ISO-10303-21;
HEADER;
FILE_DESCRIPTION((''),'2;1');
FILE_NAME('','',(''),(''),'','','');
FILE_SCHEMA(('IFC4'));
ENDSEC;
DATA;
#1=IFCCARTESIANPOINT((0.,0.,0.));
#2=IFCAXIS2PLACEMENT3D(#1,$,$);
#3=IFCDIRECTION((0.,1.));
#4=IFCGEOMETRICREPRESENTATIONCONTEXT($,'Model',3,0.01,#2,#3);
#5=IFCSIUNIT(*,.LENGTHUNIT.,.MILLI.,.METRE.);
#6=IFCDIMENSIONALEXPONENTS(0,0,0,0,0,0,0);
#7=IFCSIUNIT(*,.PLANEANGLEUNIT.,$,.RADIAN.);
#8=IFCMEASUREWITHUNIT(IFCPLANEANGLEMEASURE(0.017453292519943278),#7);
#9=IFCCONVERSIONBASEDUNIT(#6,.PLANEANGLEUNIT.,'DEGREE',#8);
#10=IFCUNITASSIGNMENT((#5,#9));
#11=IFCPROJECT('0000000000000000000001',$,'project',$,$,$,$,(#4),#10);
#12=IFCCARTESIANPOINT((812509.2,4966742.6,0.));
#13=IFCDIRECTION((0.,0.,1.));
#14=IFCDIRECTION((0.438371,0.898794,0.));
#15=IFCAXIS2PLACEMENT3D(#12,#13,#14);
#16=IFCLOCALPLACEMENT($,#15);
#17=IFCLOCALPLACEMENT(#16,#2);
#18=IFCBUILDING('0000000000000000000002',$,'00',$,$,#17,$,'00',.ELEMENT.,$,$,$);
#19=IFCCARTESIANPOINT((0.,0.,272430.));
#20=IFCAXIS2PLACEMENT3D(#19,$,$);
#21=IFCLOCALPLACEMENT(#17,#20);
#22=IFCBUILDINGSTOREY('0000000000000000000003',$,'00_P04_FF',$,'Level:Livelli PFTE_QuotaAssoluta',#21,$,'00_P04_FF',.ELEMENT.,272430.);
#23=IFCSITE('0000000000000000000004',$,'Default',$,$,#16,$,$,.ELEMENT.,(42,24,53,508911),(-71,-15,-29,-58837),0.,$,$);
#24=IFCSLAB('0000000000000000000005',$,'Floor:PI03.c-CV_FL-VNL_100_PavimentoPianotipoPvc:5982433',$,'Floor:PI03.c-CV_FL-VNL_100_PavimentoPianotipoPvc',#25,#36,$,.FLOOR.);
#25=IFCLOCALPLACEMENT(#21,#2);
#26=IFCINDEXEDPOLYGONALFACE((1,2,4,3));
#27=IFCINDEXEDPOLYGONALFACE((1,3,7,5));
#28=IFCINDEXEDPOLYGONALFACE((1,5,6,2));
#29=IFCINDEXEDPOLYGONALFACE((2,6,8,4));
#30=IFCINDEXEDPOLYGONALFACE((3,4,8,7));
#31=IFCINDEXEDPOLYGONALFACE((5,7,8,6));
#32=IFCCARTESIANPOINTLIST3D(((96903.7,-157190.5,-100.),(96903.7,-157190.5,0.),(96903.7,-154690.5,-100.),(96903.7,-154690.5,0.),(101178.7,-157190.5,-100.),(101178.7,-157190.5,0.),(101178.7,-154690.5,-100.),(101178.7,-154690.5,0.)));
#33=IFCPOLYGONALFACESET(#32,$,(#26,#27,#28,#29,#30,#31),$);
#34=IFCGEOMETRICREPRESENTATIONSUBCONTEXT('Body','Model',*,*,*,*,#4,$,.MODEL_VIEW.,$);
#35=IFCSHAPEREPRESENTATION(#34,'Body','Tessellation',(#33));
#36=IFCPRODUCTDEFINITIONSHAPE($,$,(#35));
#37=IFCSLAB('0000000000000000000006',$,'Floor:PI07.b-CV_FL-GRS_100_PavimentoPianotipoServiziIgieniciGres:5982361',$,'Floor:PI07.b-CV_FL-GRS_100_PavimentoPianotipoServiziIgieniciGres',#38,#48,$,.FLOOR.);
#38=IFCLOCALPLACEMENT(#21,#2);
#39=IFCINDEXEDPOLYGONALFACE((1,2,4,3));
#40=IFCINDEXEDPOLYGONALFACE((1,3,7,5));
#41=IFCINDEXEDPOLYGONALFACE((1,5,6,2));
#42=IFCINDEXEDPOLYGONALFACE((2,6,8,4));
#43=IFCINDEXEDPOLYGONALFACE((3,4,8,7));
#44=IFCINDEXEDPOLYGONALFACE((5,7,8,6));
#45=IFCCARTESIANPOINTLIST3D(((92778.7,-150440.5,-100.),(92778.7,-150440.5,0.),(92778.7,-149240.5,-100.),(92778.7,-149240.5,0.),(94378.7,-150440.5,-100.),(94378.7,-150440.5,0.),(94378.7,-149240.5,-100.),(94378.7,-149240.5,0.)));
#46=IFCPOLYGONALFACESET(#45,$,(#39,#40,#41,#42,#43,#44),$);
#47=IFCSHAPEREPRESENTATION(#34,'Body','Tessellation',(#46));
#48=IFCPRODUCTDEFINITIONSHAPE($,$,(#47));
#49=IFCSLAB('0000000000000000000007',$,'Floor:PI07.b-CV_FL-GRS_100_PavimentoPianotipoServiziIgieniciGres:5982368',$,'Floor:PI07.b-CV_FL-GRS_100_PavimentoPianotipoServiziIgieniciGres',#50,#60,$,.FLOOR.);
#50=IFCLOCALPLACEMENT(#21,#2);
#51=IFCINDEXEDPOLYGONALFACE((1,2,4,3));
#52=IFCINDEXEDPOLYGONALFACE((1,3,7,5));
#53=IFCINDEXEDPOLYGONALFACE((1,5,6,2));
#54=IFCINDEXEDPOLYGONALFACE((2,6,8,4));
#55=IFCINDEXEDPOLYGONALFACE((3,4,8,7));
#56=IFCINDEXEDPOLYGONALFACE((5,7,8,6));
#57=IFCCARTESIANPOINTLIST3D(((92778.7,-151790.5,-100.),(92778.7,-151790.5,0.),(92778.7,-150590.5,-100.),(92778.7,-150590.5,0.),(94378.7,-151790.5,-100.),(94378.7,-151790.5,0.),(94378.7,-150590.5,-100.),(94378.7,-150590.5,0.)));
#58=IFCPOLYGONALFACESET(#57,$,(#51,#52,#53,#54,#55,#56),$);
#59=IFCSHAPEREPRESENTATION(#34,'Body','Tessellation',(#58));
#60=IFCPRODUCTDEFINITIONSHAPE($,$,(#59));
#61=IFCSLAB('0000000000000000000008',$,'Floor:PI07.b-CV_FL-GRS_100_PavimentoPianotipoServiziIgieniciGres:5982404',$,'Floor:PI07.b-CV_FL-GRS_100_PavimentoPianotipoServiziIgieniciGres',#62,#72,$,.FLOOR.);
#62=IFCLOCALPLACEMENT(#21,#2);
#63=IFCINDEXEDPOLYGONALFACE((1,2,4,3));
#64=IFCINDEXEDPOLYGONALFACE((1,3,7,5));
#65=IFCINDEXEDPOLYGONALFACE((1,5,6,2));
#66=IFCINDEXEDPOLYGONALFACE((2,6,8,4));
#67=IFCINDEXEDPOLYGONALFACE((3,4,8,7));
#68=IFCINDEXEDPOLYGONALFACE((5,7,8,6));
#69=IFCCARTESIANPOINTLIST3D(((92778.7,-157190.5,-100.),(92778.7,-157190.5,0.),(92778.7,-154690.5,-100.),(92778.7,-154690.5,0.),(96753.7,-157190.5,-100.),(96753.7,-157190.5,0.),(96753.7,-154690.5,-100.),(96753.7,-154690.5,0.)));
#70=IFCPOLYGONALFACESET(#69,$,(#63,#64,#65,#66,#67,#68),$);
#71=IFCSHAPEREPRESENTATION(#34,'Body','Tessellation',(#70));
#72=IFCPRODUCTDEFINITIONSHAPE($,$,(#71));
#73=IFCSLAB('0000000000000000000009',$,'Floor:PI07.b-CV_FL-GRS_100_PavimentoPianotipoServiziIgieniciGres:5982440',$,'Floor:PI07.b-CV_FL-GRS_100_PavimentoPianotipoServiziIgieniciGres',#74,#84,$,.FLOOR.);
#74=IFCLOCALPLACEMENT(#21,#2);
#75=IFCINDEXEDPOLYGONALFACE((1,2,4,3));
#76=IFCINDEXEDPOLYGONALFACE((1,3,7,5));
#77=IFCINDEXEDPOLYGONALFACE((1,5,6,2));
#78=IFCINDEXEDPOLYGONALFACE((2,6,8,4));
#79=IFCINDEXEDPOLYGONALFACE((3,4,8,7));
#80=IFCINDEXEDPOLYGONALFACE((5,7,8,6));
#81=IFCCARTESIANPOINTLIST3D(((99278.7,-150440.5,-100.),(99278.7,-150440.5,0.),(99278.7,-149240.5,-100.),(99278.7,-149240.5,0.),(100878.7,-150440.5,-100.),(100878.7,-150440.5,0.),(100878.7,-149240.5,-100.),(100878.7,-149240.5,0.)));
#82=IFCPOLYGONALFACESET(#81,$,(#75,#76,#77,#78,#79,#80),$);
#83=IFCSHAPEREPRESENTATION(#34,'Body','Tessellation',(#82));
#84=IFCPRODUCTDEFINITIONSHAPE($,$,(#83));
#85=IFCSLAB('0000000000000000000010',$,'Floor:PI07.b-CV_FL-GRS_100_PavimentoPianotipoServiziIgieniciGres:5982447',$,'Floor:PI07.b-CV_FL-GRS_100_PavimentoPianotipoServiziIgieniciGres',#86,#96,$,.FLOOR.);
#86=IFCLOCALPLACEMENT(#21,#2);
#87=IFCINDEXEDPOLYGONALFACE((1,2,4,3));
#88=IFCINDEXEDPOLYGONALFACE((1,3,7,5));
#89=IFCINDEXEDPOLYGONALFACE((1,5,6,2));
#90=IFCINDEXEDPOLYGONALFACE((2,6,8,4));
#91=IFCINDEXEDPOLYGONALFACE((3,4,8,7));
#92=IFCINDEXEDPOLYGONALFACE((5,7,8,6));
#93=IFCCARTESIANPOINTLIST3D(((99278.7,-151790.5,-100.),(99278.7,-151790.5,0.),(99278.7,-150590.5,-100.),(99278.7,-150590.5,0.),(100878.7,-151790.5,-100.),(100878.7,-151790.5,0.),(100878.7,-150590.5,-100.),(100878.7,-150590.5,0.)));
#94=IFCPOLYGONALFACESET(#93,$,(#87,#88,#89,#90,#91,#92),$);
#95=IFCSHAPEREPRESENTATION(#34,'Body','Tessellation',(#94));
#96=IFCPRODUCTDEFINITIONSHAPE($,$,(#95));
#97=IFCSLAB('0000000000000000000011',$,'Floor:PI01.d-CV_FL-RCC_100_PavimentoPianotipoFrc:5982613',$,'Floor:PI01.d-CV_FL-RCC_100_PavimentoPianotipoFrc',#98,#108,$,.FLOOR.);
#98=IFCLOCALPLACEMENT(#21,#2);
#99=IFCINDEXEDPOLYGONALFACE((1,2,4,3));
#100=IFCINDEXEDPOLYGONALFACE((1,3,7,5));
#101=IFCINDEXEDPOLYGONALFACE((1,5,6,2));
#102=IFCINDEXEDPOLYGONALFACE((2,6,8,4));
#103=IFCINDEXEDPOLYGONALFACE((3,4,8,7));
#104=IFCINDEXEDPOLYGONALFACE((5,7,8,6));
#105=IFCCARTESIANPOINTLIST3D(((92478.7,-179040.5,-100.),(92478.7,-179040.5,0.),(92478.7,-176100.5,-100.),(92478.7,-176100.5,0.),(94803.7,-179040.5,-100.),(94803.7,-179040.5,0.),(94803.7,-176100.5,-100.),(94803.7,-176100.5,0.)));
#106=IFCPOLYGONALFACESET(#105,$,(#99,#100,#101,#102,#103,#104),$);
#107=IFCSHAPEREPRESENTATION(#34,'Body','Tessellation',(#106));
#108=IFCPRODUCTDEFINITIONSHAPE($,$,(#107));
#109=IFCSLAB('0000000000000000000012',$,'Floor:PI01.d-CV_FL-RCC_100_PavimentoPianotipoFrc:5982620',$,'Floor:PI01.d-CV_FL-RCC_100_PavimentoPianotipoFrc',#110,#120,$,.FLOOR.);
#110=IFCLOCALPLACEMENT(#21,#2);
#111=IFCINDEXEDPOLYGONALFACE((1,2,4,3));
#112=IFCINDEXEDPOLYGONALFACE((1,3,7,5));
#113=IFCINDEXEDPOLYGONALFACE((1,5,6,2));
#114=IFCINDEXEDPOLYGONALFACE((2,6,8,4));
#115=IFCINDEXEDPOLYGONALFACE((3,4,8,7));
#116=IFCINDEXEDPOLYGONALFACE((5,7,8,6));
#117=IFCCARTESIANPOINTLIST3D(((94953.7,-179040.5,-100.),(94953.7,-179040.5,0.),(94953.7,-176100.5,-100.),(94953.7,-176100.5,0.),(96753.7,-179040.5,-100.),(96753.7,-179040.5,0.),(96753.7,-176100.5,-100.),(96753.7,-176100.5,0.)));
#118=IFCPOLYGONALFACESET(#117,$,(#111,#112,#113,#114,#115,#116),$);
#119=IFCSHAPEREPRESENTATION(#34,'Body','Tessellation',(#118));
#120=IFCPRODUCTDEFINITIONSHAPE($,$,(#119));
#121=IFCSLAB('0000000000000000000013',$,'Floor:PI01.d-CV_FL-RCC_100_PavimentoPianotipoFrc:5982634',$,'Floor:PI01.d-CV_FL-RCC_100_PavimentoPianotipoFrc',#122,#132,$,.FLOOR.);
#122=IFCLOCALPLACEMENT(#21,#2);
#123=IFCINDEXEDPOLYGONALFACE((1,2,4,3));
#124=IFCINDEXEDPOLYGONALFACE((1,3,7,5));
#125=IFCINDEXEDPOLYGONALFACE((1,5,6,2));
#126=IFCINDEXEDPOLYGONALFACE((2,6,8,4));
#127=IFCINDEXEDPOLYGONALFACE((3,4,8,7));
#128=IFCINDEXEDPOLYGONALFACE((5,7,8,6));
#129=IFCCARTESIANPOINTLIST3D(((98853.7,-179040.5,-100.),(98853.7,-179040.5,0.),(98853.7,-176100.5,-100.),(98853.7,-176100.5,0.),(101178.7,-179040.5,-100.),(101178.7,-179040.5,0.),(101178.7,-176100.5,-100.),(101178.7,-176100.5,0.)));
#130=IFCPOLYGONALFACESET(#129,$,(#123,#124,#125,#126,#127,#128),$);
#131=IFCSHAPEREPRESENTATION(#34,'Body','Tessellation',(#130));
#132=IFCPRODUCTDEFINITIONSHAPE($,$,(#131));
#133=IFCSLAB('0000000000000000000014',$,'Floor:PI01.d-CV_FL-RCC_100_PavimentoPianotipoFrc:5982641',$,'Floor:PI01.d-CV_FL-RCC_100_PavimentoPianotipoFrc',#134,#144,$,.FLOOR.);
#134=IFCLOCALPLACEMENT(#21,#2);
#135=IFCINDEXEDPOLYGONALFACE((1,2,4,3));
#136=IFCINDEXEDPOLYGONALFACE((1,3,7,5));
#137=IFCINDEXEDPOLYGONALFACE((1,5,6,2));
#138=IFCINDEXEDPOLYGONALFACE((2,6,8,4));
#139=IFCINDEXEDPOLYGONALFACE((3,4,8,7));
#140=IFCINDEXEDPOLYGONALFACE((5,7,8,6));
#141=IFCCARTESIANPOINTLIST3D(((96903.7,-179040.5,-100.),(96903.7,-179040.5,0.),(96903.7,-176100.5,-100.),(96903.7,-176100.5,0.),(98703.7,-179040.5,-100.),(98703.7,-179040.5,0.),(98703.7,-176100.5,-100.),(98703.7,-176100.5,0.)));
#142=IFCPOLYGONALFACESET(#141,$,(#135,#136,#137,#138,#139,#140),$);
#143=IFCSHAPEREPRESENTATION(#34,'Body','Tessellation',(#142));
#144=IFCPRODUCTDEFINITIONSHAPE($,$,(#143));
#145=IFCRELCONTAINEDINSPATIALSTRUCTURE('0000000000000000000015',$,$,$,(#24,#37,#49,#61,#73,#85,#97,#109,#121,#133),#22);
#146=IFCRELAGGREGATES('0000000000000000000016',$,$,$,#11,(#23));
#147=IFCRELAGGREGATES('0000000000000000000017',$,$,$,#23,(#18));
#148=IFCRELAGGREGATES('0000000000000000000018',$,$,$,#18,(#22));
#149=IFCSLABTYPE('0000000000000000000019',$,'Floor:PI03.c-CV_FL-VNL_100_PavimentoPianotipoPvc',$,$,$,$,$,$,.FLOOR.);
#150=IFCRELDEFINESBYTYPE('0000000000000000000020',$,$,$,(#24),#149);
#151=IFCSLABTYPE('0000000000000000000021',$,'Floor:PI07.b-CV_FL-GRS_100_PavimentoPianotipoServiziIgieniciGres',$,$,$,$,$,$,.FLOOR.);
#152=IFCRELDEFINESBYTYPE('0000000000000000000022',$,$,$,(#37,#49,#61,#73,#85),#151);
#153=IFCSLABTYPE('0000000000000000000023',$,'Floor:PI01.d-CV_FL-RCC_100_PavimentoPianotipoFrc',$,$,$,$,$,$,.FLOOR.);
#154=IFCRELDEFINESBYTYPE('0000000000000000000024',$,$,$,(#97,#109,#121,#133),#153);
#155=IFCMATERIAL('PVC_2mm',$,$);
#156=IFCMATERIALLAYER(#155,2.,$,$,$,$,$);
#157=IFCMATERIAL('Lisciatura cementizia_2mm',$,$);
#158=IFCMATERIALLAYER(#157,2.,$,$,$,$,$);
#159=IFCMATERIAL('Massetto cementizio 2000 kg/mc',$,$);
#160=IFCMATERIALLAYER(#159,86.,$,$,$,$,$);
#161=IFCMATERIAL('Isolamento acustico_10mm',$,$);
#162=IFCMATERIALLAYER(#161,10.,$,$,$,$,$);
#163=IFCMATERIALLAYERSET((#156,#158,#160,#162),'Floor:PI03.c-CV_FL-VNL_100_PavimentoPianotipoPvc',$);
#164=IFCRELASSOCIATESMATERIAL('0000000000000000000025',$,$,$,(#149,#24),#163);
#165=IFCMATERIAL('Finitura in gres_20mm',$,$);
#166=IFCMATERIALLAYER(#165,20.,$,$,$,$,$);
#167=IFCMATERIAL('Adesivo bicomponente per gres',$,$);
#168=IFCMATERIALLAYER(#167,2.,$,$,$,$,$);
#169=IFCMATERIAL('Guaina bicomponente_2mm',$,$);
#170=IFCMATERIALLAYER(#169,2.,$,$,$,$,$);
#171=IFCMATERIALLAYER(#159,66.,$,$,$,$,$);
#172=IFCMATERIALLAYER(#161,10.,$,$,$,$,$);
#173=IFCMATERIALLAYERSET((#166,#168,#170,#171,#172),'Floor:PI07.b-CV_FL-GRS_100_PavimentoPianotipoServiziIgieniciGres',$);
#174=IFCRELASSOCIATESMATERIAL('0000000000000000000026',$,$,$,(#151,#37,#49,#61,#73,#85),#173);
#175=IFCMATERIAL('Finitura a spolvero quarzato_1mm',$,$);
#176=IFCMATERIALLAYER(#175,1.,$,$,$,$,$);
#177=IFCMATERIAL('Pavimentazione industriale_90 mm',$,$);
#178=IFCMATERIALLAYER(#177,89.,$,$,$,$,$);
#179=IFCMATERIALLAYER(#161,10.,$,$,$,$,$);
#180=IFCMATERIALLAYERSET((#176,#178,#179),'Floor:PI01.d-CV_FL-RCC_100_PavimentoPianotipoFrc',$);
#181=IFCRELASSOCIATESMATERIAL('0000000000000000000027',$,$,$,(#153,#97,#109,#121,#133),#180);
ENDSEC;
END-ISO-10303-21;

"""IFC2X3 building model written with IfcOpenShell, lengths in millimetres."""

from ifc_helpers import new_model, entity, si_unit, converted_unit, direction, frame, frame_2d, origin, place, context, subcontext, project, spatial, rectangle, extrude, material, layer, layer_set, layer_usage, type_object, element, save


model = new_model("IFC2X3")

# Units and contexts
model_context = context("Model", 3, precision=0.01, world=origin(), true_north=direction((0.0, 1.0)))
body_context = subcontext(model_context, "Body", "Model", "MODEL_VIEW")
ifc_project = project(units=[si_unit("LENGTHUNIT", "METRE", prefix="MILLI"), converted_unit("PLANEANGLEUNIT", "DEGREE", entity("IfcPlaneAngleMeasure", 0.017453292519943278), si_unit("PLANEANGLEUNIT", "RADIAN"), dimensions=[0, 0, 0, 0, 0, 0, 0])], contexts=[model_context])

# Site, building, storey
site_placement = place(None, frame((812509.2, 4966742.6, 0.0), z_axis=(0.0, 0.0, 1.0), x_axis=(0.438371, 0.898794, 0.0)))
site = spatial("IfcSite", under=ifc_project, at=site_placement, Name="Default", CompositionType="ELEMENT", RefLatitude=(42, 24, 53, 508911), RefLongitude=(-71, -15, -29, -58837), RefElevation=0.0)
building_placement = place(site_placement, origin())
building = spatial("IfcBuilding", under=site, at=building_placement, Name="00", LongName="00", CompositionType="ELEMENT")
storey_placement = place(building_placement, frame((0.0, 0.0, 272430.0)))
storey = spatial("IfcBuildingStorey", under=building, at=storey_placement, Name="00_P04_FF", ObjectType="Level:Livelli PFTE_QuotaAssoluta", LongName="00_P04_FF", CompositionType="ELEMENT", Elevation=272430.0)

# Slabs
ifc_material_1 = material(Name="PVC_2mm")
ifc_layer_1 = layer(ifc_material_1, 2.0)
ifc_material_2 = material(Name="Lisciatura cementizia_2mm")
ifc_layer_2 = layer(ifc_material_2, 2.0)
ifc_material_3 = material(Name="Massetto cementizio 2000 kg/mc")
ifc_layer_3 = layer(ifc_material_3, 86.0)
ifc_material_4 = material(Name="Isolamento acustico_10mm")
ifc_layer_4 = layer(ifc_material_4, 10.0)
ifc_layer_set_1 = layer_set([ifc_layer_1, ifc_layer_2, ifc_layer_3, ifc_layer_4], Name="Floor:PI03.c-CV_FL-VNL_100_PavimentoPianotipoPvc")
slab_type_1 = type_object("IfcSlabType", Name="Floor:PI03.c-CV_FL-VNL_100_PavimentoPianotipoPvc", PredefinedType="FLOOR", material=ifc_layer_set_1)
ifc_layer_usage_1 = layer_usage(ifc_layer_set_1, "AXIS3", "POSITIVE", 0.0)
slab_1_placement = place(storey_placement, origin())
element("IfcSlab", 1, at=slab_1_placement, inside=storey, type_object=slab_type_1, material=ifc_layer_usage_1, Name="Floor:PI03.c-CV_FL-VNL_100_PavimentoPianotipoPvc:5982433", ObjectType="Floor:PI03.c-CV_FL-VNL_100_PavimentoPianotipoPvc", PredefinedType="FLOOR", context=body_context, shape_type="SweptSolid", body=[
    extrude(rectangle(XDim=2500.0, YDim=4275.0, at=frame_2d((0.0, 0.0), x_axis=(1.0, 0.0))), frame((99041.2, -155940.5, 0.0), z_axis=(0.0, 0.0, -1.0), x_axis=(0.0, 1.0, 0.0)), (0.0, 0.0, 1.0), 100.0),
])
ifc_material_5 = material(Name="Finitura in gres_20mm")
ifc_layer_5 = layer(ifc_material_5, 20.0)
ifc_material_6 = material(Name="Adesivo bicomponente per gres")
ifc_layer_6 = layer(ifc_material_6, 2.0)
ifc_material_7 = material(Name="Guaina bicomponente_2mm")
ifc_layer_7 = layer(ifc_material_7, 2.0)
ifc_layer_8 = layer(ifc_material_3, 66.0)
ifc_layer_9 = layer(ifc_material_4, 10.0)
ifc_layer_set_2 = layer_set([ifc_layer_5, ifc_layer_6, ifc_layer_7, ifc_layer_8, ifc_layer_9], Name="Floor:PI07.b-CV_FL-GRS_100_PavimentoPianotipoServiziIgieniciGres")
slab_type_2 = type_object("IfcSlabType", Name="Floor:PI07.b-CV_FL-GRS_100_PavimentoPianotipoServiziIgieniciGres", PredefinedType="FLOOR", material=ifc_layer_set_2)
ifc_layer_usage_2 = layer_usage(ifc_layer_set_2, "AXIS3", "POSITIVE", 0.0)
slab_2_placement = place(storey_placement, origin())
element("IfcSlab", 2, at=slab_2_placement, inside=storey, type_object=slab_type_2, material=ifc_layer_usage_2, Name="Floor:PI07.b-CV_FL-GRS_100_PavimentoPianotipoServiziIgieniciGres:5982361", ObjectType="Floor:PI07.b-CV_FL-GRS_100_PavimentoPianotipoServiziIgieniciGres", PredefinedType="FLOOR", context=body_context, shape_type="SweptSolid", body=[
    extrude(rectangle(XDim=1200.0, YDim=1600.0, at=frame_2d((0.0, 0.0), x_axis=(1.0, 0.0))), frame((93578.7, -149840.5, 0.0), z_axis=(0.0, 0.0, -1.0), x_axis=(0.0, 1.0, 0.0)), (0.0, 0.0, 1.0), 100.0),
])
ifc_layer_usage_3 = layer_usage(ifc_layer_set_2, "AXIS3", "POSITIVE", 0.0)
slab_3_placement = place(storey_placement, origin())
element("IfcSlab", 3, at=slab_3_placement, inside=storey, type_object=slab_type_2, material=ifc_layer_usage_3, Name="Floor:PI07.b-CV_FL-GRS_100_PavimentoPianotipoServiziIgieniciGres:5982368", ObjectType="Floor:PI07.b-CV_FL-GRS_100_PavimentoPianotipoServiziIgieniciGres", PredefinedType="FLOOR", context=body_context, shape_type="SweptSolid", body=[
    extrude(rectangle(XDim=1200.0, YDim=1600.0, at=frame_2d((0.0, 0.0), x_axis=(1.0, 0.0))), frame((93578.7, -151190.5, 0.0), z_axis=(0.0, 0.0, -1.0), x_axis=(0.0, 1.0, 0.0)), (0.0, 0.0, 1.0), 100.0),
])
ifc_layer_usage_4 = layer_usage(ifc_layer_set_2, "AXIS3", "POSITIVE", 0.0)
slab_4_placement = place(storey_placement, origin())
element("IfcSlab", 4, at=slab_4_placement, inside=storey, type_object=slab_type_2, material=ifc_layer_usage_4, Name="Floor:PI07.b-CV_FL-GRS_100_PavimentoPianotipoServiziIgieniciGres:5982404", ObjectType="Floor:PI07.b-CV_FL-GRS_100_PavimentoPianotipoServiziIgieniciGres", PredefinedType="FLOOR", context=body_context, shape_type="SweptSolid", body=[
    extrude(rectangle(XDim=2500.0, YDim=3975.0, at=frame_2d((0.0, 0.0), x_axis=(1.0, 0.0))), frame((94766.2, -155940.5, 0.0), z_axis=(0.0, 0.0, -1.0), x_axis=(0.0, 1.0, 0.0)), (0.0, 0.0, 1.0), 100.0),
])
ifc_layer_usage_5 = layer_usage(ifc_layer_set_2, "AXIS3", "POSITIVE", 0.0)
slab_5_placement = place(storey_placement, origin())
element("IfcSlab", 5, at=slab_5_placement, inside=storey, type_object=slab_type_2, material=ifc_layer_usage_5, Name="Floor:PI07.b-CV_FL-GRS_100_PavimentoPianotipoServiziIgieniciGres:5982440", ObjectType="Floor:PI07.b-CV_FL-GRS_100_PavimentoPianotipoServiziIgieniciGres", PredefinedType="FLOOR", context=body_context, shape_type="SweptSolid", body=[
    extrude(rectangle(XDim=1200.0, YDim=1600.0, at=frame_2d((0.0, 0.0), x_axis=(1.0, 0.0))), frame((100078.7, -149840.5, 0.0), z_axis=(0.0, 0.0, -1.0), x_axis=(0.0, 1.0, 0.0)), (0.0, 0.0, 1.0), 100.0),
])
ifc_layer_usage_6 = layer_usage(ifc_layer_set_2, "AXIS3", "POSITIVE", 0.0)
slab_6_placement = place(storey_placement, origin())
element("IfcSlab", 6, at=slab_6_placement, inside=storey, type_object=slab_type_2, material=ifc_layer_usage_6, Name="Floor:PI07.b-CV_FL-GRS_100_PavimentoPianotipoServiziIgieniciGres:5982447", ObjectType="Floor:PI07.b-CV_FL-GRS_100_PavimentoPianotipoServiziIgieniciGres", PredefinedType="FLOOR", context=body_context, shape_type="SweptSolid", body=[
    extrude(rectangle(XDim=1200.0, YDim=1600.0, at=frame_2d((0.0, 0.0), x_axis=(1.0, 0.0))), frame((100078.7, -151190.5, 0.0), z_axis=(0.0, 0.0, -1.0), x_axis=(0.0, 1.0, 0.0)), (0.0, 0.0, 1.0), 100.0),
])
ifc_material_8 = material(Name="Finitura a spolvero quarzato_1mm")
ifc_layer_10 = layer(ifc_material_8, 1.0)
ifc_material_9 = material(Name="Pavimentazione industriale_90 mm")
ifc_layer_11 = layer(ifc_material_9, 89.0)
ifc_layer_12 = layer(ifc_material_4, 10.0)
ifc_layer_set_3 = layer_set([ifc_layer_10, ifc_layer_11, ifc_layer_12], Name="Floor:PI01.d-CV_FL-RCC_100_PavimentoPianotipoFrc")
slab_type_3 = type_object("IfcSlabType", Name="Floor:PI01.d-CV_FL-RCC_100_PavimentoPianotipoFrc", PredefinedType="FLOOR", material=ifc_layer_set_3)
ifc_layer_usage_7 = layer_usage(ifc_layer_set_3, "AXIS3", "POSITIVE", 0.0)
slab_7_placement = place(storey_placement, origin())
element("IfcSlab", 7, at=slab_7_placement, inside=storey, type_object=slab_type_3, material=ifc_layer_usage_7, Name="Floor:PI01.d-CV_FL-RCC_100_PavimentoPianotipoFrc:5982613", ObjectType="Floor:PI01.d-CV_FL-RCC_100_PavimentoPianotipoFrc", PredefinedType="FLOOR", context=body_context, shape_type="SweptSolid", body=[
    extrude(rectangle(XDim=2940.0, YDim=2325.0, at=frame_2d((0.0, 0.0), x_axis=(1.0, 0.0))), frame((93641.2, -177570.5, 0.0), z_axis=(0.0, 0.0, -1.0), x_axis=(0.0, 1.0, 0.0)), (0.0, 0.0, 1.0), 100.0),
])
ifc_layer_usage_8 = layer_usage(ifc_layer_set_3, "AXIS3", "POSITIVE", 0.0)
slab_8_placement = place(storey_placement, origin())
element("IfcSlab", 8, at=slab_8_placement, inside=storey, type_object=slab_type_3, material=ifc_layer_usage_8, Name="Floor:PI01.d-CV_FL-RCC_100_PavimentoPianotipoFrc:5982620", ObjectType="Floor:PI01.d-CV_FL-RCC_100_PavimentoPianotipoFrc", PredefinedType="FLOOR", context=body_context, shape_type="SweptSolid", body=[
    extrude(rectangle(XDim=2940.0, YDim=1800.0, at=frame_2d((0.0, 0.0), x_axis=(1.0, 0.0))), frame((95853.7, -177570.5, 0.0), z_axis=(0.0, 0.0, -1.0), x_axis=(0.0, 1.0, 0.0)), (0.0, 0.0, 1.0), 100.0),
])
ifc_layer_usage_9 = layer_usage(ifc_layer_set_3, "AXIS3", "POSITIVE", 0.0)
slab_9_placement = place(storey_placement, origin())
element("IfcSlab", 9, at=slab_9_placement, inside=storey, type_object=slab_type_3, material=ifc_layer_usage_9, Name="Floor:PI01.d-CV_FL-RCC_100_PavimentoPianotipoFrc:5982634", ObjectType="Floor:PI01.d-CV_FL-RCC_100_PavimentoPianotipoFrc", PredefinedType="FLOOR", context=body_context, shape_type="SweptSolid", body=[
    extrude(rectangle(XDim=2940.0, YDim=2325.0, at=frame_2d((0.0, 0.0), x_axis=(1.0, 0.0))), frame((100016.2, -177570.5, 0.0), z_axis=(0.0, 0.0, -1.0), x_axis=(0.0, 1.0, 0.0)), (0.0, 0.0, 1.0), 100.0),
])
ifc_layer_usage_10 = layer_usage(ifc_layer_set_3, "AXIS3", "POSITIVE", 0.0)
slab_10_placement = place(storey_placement, origin())
element("IfcSlab", 10, at=slab_10_placement, inside=storey, type_object=slab_type_3, material=ifc_layer_usage_10, Name="Floor:PI01.d-CV_FL-RCC_100_PavimentoPianotipoFrc:5982641", ObjectType="Floor:PI01.d-CV_FL-RCC_100_PavimentoPianotipoFrc", PredefinedType="FLOOR", context=body_context, shape_type="SweptSolid", body=[
    extrude(rectangle(XDim=2940.0, YDim=1800.0, at=frame_2d((0.0, 0.0), x_axis=(1.0, 0.0))), frame((97803.7, -177570.5, 0.0), z_axis=(0.0, 0.0, -1.0), x_axis=(0.0, 1.0, 0.0)), (0.0, 0.0, 1.0), 100.0),
])

save(model, "model.ifc")
